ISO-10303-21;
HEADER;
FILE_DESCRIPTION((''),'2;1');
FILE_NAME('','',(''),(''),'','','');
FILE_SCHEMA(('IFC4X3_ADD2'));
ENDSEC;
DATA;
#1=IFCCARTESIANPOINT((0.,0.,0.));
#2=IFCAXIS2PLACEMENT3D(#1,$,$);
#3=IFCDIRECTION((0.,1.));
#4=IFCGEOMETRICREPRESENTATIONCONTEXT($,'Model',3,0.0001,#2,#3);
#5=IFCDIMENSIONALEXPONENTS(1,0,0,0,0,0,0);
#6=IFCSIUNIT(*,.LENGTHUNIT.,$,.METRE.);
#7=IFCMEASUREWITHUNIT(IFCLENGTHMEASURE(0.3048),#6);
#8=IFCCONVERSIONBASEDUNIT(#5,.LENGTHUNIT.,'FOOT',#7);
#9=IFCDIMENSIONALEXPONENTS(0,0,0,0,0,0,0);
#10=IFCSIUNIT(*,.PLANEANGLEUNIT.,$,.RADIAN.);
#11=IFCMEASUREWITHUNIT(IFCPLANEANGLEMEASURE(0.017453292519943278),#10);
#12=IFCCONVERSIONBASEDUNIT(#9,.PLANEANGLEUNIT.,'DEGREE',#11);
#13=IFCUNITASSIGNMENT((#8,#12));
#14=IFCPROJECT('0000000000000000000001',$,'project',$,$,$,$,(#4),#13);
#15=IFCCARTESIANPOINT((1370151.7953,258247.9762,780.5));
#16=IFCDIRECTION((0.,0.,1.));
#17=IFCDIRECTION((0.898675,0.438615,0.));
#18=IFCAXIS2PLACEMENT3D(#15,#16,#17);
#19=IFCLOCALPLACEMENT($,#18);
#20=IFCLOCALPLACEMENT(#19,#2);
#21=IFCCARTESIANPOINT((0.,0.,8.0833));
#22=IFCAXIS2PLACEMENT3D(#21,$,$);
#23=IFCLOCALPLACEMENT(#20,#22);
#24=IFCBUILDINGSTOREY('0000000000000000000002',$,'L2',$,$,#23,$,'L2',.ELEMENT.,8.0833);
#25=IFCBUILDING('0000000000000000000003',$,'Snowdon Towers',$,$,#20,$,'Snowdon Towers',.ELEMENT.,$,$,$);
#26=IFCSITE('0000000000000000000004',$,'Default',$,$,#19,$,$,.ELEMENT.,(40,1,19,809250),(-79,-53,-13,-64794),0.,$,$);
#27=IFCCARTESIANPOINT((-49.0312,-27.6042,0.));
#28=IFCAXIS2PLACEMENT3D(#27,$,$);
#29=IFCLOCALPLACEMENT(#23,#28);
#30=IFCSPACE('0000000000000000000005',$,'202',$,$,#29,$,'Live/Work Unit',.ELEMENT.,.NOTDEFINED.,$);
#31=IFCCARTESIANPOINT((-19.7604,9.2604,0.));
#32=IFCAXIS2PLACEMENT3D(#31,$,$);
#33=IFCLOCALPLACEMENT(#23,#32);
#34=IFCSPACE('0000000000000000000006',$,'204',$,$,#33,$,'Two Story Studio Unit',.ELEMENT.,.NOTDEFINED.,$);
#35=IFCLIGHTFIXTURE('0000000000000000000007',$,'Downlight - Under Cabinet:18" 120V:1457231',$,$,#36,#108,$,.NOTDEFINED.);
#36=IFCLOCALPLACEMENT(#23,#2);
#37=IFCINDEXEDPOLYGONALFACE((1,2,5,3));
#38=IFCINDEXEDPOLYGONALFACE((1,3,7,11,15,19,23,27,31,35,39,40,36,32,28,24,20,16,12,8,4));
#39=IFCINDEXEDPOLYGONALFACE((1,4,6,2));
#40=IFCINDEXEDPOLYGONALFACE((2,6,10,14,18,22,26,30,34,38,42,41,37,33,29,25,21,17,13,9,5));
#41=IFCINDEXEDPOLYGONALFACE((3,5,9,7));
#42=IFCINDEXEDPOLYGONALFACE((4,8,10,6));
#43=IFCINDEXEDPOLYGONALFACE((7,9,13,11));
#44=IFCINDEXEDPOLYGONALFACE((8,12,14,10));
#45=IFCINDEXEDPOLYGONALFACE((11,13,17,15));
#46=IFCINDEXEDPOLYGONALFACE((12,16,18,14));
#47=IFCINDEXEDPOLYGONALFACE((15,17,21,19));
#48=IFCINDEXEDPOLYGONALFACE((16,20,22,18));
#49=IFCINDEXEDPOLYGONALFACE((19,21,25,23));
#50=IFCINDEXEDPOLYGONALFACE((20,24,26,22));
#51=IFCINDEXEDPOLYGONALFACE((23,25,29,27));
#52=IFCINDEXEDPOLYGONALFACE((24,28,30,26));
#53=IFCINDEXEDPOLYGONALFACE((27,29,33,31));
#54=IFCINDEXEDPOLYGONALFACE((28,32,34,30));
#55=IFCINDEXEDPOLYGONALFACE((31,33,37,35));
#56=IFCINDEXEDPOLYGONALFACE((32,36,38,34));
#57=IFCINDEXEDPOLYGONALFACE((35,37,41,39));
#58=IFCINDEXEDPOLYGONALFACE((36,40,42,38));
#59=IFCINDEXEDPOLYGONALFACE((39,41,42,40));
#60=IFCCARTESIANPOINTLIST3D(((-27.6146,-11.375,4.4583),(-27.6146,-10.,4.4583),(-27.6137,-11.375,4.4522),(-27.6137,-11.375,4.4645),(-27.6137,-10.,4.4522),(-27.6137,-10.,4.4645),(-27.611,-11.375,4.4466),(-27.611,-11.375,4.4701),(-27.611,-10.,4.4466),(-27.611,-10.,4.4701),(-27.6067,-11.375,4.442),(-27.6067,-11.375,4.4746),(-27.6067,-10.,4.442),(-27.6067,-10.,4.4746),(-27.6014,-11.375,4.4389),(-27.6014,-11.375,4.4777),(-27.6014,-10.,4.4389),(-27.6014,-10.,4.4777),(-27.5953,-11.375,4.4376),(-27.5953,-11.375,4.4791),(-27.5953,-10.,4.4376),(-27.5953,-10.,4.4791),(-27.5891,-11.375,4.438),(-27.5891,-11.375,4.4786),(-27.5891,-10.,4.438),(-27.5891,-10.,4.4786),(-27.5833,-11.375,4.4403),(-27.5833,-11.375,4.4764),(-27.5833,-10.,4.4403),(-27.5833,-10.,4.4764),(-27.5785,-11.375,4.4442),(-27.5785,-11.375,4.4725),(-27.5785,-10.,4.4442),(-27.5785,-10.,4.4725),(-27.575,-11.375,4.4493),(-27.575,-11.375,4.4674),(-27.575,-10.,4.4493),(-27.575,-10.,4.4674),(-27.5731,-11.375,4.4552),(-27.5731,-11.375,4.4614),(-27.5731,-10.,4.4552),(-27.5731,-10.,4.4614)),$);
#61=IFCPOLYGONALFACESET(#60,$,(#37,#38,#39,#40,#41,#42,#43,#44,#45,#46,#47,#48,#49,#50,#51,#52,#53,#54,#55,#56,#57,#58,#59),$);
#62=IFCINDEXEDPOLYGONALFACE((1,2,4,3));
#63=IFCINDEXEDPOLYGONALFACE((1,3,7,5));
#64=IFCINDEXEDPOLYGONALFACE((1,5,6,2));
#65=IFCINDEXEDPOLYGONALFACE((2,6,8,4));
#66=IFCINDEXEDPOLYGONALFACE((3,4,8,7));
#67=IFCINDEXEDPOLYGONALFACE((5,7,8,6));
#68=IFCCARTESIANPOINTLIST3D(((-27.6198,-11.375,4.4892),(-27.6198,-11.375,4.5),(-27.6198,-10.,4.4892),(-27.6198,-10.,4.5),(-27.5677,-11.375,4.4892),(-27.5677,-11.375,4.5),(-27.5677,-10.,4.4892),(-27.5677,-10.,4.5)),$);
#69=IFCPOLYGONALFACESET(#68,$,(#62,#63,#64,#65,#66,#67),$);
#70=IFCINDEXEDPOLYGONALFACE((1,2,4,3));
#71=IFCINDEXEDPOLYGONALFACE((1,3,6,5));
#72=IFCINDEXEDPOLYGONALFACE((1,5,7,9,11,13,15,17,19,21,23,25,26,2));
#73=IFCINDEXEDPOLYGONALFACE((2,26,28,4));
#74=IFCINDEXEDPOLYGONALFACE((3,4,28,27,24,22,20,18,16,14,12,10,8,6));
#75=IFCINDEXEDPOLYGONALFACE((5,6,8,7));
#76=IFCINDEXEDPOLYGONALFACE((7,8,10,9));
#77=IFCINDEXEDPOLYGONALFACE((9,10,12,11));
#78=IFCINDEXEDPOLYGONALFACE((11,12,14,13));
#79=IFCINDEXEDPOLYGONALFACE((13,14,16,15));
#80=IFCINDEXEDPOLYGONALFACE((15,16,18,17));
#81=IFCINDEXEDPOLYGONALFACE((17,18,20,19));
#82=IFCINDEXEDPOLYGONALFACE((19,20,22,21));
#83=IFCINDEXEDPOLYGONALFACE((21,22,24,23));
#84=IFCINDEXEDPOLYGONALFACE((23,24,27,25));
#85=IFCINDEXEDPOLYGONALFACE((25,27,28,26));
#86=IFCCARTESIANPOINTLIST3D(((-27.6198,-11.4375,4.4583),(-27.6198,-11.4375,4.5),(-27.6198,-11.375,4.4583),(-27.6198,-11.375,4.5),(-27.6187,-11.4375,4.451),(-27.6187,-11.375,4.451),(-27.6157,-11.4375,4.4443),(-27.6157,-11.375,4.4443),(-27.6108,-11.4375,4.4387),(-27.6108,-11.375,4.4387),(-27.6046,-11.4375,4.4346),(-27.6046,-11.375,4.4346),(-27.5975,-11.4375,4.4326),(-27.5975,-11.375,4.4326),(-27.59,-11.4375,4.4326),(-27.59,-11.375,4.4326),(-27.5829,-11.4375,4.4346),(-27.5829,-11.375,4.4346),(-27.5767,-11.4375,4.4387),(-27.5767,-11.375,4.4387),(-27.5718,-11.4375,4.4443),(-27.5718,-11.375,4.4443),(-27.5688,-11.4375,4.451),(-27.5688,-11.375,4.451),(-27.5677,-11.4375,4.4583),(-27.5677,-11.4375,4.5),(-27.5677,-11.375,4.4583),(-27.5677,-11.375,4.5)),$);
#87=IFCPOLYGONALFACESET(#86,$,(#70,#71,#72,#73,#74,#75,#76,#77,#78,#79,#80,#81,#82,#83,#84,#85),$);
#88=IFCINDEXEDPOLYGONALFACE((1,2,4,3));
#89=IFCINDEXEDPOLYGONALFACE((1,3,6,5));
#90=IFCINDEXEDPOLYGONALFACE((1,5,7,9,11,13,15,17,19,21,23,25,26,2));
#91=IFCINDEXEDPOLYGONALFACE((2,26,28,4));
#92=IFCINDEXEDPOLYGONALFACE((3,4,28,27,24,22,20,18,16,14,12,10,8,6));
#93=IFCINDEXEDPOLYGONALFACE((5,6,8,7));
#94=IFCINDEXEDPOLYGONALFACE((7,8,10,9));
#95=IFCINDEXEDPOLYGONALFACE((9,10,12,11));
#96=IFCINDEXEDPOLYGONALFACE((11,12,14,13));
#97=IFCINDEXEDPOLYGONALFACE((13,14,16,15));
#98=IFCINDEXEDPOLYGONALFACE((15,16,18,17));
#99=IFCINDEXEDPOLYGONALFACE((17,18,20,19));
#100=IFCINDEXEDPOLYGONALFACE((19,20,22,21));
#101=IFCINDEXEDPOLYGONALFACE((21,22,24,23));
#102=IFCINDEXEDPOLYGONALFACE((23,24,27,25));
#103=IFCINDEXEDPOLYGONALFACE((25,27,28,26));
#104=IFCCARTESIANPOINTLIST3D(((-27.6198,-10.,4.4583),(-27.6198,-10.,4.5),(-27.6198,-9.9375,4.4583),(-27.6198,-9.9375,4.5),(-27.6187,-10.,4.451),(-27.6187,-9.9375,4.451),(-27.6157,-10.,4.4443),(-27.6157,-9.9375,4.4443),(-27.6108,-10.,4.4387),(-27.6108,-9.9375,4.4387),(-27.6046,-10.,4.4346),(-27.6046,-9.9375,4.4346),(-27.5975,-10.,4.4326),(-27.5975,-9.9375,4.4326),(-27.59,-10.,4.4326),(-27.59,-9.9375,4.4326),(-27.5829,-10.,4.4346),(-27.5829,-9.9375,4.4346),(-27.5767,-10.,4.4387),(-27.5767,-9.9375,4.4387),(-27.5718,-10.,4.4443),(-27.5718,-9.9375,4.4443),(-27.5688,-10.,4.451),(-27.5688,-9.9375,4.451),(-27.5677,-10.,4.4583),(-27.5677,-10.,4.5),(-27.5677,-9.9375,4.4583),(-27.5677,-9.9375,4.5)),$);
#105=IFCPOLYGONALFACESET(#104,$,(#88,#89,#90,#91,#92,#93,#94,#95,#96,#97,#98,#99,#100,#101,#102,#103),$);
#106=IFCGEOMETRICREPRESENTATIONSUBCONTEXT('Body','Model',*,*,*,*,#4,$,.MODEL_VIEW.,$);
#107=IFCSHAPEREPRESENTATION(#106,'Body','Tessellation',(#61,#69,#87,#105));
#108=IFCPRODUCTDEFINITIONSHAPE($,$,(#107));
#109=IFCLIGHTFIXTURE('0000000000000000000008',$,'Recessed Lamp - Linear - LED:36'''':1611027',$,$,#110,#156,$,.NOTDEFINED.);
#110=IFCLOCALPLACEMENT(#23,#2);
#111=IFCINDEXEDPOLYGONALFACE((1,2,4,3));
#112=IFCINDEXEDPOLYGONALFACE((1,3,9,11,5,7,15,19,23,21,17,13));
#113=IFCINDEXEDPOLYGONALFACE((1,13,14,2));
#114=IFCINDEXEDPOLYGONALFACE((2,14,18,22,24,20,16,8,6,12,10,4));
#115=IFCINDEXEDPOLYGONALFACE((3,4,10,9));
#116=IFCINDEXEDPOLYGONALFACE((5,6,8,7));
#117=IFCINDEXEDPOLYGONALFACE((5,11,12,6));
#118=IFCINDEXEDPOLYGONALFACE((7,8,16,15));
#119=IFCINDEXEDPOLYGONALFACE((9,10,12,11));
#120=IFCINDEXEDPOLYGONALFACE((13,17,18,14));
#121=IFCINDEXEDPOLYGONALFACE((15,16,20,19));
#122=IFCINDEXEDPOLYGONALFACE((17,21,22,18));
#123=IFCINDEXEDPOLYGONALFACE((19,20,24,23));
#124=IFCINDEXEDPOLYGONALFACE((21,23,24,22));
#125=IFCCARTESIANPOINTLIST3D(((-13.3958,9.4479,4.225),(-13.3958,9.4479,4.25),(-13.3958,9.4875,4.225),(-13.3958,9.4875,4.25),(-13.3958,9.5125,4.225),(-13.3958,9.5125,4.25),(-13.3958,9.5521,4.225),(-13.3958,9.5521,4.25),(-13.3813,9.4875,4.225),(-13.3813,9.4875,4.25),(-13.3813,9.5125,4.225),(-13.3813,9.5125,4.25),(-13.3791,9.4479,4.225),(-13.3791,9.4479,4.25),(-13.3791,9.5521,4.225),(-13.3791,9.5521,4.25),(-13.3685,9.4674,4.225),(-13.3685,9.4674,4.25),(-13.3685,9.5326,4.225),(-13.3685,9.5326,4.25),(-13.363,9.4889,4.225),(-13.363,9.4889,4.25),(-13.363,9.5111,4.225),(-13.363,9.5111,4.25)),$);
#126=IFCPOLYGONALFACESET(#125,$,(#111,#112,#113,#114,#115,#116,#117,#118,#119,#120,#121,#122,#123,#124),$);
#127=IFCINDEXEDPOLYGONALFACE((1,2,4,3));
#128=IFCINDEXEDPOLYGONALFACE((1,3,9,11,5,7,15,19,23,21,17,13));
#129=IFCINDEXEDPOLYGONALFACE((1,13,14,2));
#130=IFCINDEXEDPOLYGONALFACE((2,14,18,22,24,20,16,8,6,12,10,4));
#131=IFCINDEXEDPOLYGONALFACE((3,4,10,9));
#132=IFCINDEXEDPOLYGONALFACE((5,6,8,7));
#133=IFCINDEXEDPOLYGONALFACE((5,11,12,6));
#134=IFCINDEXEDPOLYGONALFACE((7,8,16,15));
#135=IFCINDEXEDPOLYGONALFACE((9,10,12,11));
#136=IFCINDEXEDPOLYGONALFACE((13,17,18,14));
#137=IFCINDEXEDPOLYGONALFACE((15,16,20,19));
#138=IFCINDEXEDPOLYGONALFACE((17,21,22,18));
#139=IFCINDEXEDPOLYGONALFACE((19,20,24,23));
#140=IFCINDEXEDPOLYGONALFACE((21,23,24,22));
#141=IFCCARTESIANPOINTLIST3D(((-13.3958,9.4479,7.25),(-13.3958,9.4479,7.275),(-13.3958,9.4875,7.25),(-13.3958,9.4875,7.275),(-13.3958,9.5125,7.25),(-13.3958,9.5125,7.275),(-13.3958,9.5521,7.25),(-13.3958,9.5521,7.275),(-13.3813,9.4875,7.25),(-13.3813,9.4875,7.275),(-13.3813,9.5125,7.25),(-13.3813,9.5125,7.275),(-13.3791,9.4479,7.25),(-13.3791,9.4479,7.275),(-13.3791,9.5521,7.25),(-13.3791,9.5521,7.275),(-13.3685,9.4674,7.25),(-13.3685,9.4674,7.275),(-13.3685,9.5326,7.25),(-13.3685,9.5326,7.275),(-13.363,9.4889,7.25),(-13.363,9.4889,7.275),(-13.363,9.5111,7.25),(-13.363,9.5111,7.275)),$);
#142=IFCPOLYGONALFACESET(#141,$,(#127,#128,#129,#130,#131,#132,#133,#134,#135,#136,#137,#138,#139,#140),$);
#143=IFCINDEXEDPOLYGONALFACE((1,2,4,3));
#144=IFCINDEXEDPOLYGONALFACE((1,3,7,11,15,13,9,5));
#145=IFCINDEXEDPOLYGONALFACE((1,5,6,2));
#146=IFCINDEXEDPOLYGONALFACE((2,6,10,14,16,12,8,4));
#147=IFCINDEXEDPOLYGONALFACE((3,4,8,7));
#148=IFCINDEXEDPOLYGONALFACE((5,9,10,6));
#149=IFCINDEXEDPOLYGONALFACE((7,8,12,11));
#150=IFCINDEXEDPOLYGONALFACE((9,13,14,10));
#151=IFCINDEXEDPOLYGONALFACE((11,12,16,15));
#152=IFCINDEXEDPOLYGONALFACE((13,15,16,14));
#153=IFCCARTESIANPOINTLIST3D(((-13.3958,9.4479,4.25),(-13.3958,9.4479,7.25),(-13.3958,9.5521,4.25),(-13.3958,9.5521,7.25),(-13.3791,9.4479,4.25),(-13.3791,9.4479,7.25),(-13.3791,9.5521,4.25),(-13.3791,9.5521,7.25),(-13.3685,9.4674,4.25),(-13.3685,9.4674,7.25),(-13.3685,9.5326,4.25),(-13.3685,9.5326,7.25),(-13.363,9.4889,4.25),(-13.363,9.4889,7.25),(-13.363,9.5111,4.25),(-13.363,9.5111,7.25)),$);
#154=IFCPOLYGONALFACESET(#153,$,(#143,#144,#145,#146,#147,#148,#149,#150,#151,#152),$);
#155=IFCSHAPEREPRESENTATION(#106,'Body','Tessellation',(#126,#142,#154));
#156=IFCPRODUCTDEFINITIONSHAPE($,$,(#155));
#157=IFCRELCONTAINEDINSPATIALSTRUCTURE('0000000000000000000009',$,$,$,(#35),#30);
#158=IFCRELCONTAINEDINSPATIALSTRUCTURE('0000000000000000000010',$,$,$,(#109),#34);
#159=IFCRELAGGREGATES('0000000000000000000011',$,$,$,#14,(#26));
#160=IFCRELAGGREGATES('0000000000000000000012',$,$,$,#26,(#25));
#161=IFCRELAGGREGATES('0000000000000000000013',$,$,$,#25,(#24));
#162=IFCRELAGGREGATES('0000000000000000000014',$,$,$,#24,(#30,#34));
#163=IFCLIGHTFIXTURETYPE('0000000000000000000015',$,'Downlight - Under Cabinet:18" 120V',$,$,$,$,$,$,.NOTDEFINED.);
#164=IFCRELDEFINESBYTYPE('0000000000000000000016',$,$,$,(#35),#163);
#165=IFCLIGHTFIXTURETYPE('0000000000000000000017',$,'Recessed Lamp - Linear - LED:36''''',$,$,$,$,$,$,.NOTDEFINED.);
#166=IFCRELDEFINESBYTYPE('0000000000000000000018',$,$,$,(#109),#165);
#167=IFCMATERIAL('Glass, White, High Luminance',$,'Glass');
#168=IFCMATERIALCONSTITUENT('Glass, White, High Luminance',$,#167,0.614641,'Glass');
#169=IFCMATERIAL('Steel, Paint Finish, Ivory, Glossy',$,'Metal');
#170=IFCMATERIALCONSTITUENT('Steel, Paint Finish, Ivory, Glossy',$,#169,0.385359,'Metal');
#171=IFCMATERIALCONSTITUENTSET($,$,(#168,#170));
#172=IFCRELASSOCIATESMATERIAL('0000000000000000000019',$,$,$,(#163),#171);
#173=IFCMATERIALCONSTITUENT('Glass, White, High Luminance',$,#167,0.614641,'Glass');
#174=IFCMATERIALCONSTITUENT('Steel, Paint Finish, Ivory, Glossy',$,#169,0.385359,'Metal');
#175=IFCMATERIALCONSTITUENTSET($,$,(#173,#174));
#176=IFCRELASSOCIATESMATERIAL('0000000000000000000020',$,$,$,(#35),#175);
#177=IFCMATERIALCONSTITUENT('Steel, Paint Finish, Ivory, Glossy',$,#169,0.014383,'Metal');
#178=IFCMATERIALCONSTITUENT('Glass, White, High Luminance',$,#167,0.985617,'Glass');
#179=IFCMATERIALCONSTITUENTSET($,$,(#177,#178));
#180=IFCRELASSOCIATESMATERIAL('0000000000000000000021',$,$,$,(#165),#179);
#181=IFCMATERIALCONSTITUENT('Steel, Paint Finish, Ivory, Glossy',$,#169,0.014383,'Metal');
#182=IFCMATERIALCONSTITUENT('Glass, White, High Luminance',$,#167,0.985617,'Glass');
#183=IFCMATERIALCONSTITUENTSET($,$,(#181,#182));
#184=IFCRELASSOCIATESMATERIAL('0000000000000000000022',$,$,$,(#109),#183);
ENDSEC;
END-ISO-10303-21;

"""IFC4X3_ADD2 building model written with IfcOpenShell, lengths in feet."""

from ifc_helpers import new_model, entity, si_unit, converted_unit, direction, frame, frame_2d, origin, origin_2d_with_axis, place, context, subcontext, project, spatial, polyline, circle_curve, parameter, trimmed, segment, composite_curve, rectangle, circle, outline, extrude, source, transform, mapped, material, constituent, constituent_set, type_object, type_shapes, element, save


model = new_model("IFC4X3_ADD2")

# Units and contexts
model_context = context("Model", 3, precision=0.0001, world=origin(), true_north=direction((0.0, 1.0)))
body_context = subcontext(model_context, "Body", "Model", "MODEL_VIEW")
ifc_project = project(units=[converted_unit("LENGTHUNIT", "FOOT", entity("IfcLengthMeasure", 0.3048), si_unit("LENGTHUNIT", "METRE"), dimensions=[1, 0, 0, 0, 0, 0, 0]), converted_unit("PLANEANGLEUNIT", "DEGREE", entity("IfcPlaneAngleMeasure", 0.017453292519943278), si_unit("PLANEANGLEUNIT", "RADIAN"), dimensions=[0, 0, 0, 0, 0, 0, 0])], contexts=[model_context])

# Site, building, storey, space
site_placement = place(None, frame((1370151.7953, 258247.9762, 780.5), z_axis=(0.0, 0.0, 1.0), x_axis=(0.898675, 0.438615, 0.0)))
site = spatial("IfcSite", under=ifc_project, at=site_placement, Name="Default", CompositionType="ELEMENT", RefLatitude=(40, 1, 19, 809250), RefLongitude=(-79, -53, -13, -64794), RefElevation=0.0)
building_placement = place(site_placement, origin())
building = spatial("IfcBuilding", under=site, at=building_placement, Name="Snowdon Towers", LongName="Snowdon Towers", CompositionType="ELEMENT")
storey_placement = place(building_placement, frame((0.0, 0.0, 8.0833)))
storey = spatial("IfcBuildingStorey", under=building, at=storey_placement, Name="L2", LongName="L2", CompositionType="ELEMENT", Elevation=8.0833)
space_1_placement = place(storey_placement, frame((-49.0312, -27.6042, 0.0)))
space_1 = spatial("IfcSpace", under=storey, at=space_1_placement, Name="202", LongName="Live/Work Unit", CompositionType="ELEMENT", PredefinedType="NOTDEFINED")

# Shared definitions
space_2_placement = place(storey_placement, frame((-19.7604, 9.2604, 0.0)))
space_2 = spatial("IfcSpace", under=storey, at=space_2_placement, Name="204", LongName="Two Story Studio Unit", CompositionType="ELEMENT", PredefinedType="NOTDEFINED")

# Light fixtures
ifc_material_1 = material(Name="Glass, White, High Luminance", Category="Glass")
ifc_constituent_1 = constituent(ifc_material_1, Name="Glass, White, High Luminance", Category="Glass", fraction=0.614641)
ifc_material_2 = material(Name="Steel, Paint Finish, Ivory, Glossy", Category="Metal")
ifc_constituent_2 = constituent(ifc_material_2, Name="Steel, Paint Finish, Ivory, Glossy", Category="Metal", fraction=0.385359)
ifc_constituent_set_1 = constituent_set(constituents=[ifc_constituent_1, ifc_constituent_2])
ifc_constituent_3 = constituent(ifc_material_1, Name="Glass, White, High Luminance", Category="Glass", fraction=0.614641)
ifc_constituent_4 = constituent(ifc_material_2, Name="Steel, Paint Finish, Ivory, Glossy", Category="Metal", fraction=0.385359)
ifc_constituent_set_2 = constituent_set(constituents=[ifc_constituent_3, ifc_constituent_4])
light_fixture_type_1 = type_object("IfcLightFixtureType", Name="Downlight - Under Cabinet:18\" 120V", PredefinedType="NOTDEFINED", material=ifc_constituent_set_2)
shared_shape_1 = source(origin(), body_context, "Body", "SweptSolid", [
    extrude(circle(Radius=0.0208, at=origin_2d_with_axis()), frame((-0.6875, 0.0, 4.4583), z_axis=(1.0, 0.0, 0.0), x_axis=(0.0, 1.0, 0.0)), (0.0, 0.0, 1.0), 1.375),
    extrude(rectangle(XDim=1.375, YDim=0.0521, at=origin_2d_with_axis()), frame((0.0, 0.0, 4.4892), z_axis=(0.0, 0.0, 1.0), x_axis=(-1.0, 0.0, 0.0)), (0.0, 0.0, 1.0), 0.0108),
    extrude(outline(composite_curve([segment(polyline([(-0.026, -0.0208), (0.026, -0.0208)]), True, "CONTINUOUS"), segment(polyline([(0.026, -0.0208), (0.026, 0.0208)]), True, "CONTINUOUS"), segment(trimmed(circle_curve(frame_2d((0.0, 0.0208), x_axis=(0.0, -1.0)), 0.026), [parameter(90.0)], [parameter(270.0)], True, "PARAMETER"), True, "CONTINUOUS"), segment(polyline([(-0.026, 0.0208), (-0.026, -0.0208)]), True, "CONTINUOUS")], self_intersect=False)), frame((-0.75, 0.0, 4.4792), z_axis=(1.0, 0.0, 0.0), x_axis=(0.0, -1.0, 0.0)), (0.0, 0.0, 1.0), 0.0625),
    extrude(outline(composite_curve([segment(polyline([(-0.0208, -0.026), (0.0208, -0.026)]), True, "CONTINUOUS"), segment(trimmed(circle_curve(frame_2d((0.0208, 0.0), x_axis=(0.0, 1.0)), 0.026), [parameter(180.0)], [parameter(360.0)], True, "PARAMETER"), True, "CONTINUOUS"), segment(polyline([(0.0208, 0.026), (-0.0208, 0.026)]), True, "CONTINUOUS"), segment(polyline([(-0.0208, 0.026), (-0.0208, -0.026)]), True, "CONTINUOUS")], self_intersect=False)), frame((0.6875, 0.0, 4.4792), z_axis=(1.0, 0.0, 0.0), x_axis=(0.0, 0.0, -1.0)), (0.0, 0.0, 1.0), 0.0625),
])
type_shapes(light_fixture_type_1, [shared_shape_1])
light_fixture_1_placement = place(space_1_placement, frame((21.4375, 16.9167, 0.0), z_axis=(0.0, 0.0, 1.0), x_axis=(0.0, 1.0, 0.0)))
element("IfcLightFixture", 1, at=light_fixture_1_placement, inside=space_1, type_object=light_fixture_type_1, material=ifc_constituent_set_1, Name="Downlight - Under Cabinet:18\" 120V:1457231", PredefinedType="NOTDEFINED", context=body_context, shape_type="MappedRepresentation", body=[
    mapped(shared_shape_1, transform((0.0, 0.0, 0.0), scale=1.0)),
])
ifc_constituent_5 = constituent(ifc_material_2, Name="Steel, Paint Finish, Ivory, Glossy", Category="Metal", fraction=0.014383)
ifc_constituent_6 = constituent(ifc_material_1, Name="Glass, White, High Luminance", Category="Glass", fraction=0.985617)
ifc_constituent_set_3 = constituent_set(constituents=[ifc_constituent_5, ifc_constituent_6])
ifc_constituent_7 = constituent(ifc_material_2, Name="Steel, Paint Finish, Ivory, Glossy", Category="Metal", fraction=0.014383)
ifc_constituent_8 = constituent(ifc_material_1, Name="Glass, White, High Luminance", Category="Glass", fraction=0.985617)
ifc_constituent_set_4 = constituent_set(constituents=[ifc_constituent_7, ifc_constituent_8])
light_fixture_type_2 = type_object("IfcLightFixtureType", Name="Recessed Lamp - Linear - LED:36''", PredefinedType="NOTDEFINED", material=ifc_constituent_set_4)
shared_shape_2 = source(origin(), body_context, "Body", "SweptSolid", [
    extrude(outline(composite_curve([segment(trimmed(circle_curve(frame_2d((0.0, -0.0633), x_axis=(1.0, 0.0)), 0.089), [parameter(54.196986)], [parameter(125.803014)], True, "PARAMETER"), True, "CONTINUOUS"), segment(polyline([(-0.0521, 0.0089), (-0.0521, -0.0078)]), True, "CONTINUOUS"), segment(polyline([(-0.0521, -0.0078), (-0.0125, -0.0078)]), True, "CONTINUOUS"), segment(polyline([(-0.0125, -0.0078), (-0.0125, 0.0068)]), True, "CONTINUOUS"), segment(polyline([(-0.0125, 0.0068), (0.0125, 0.0068)]), True, "CONTINUOUS"), segment(polyline([(0.0125, 0.0068), (0.0125, -0.0078)]), True, "CONTINUOUS"), segment(polyline([(0.0125, -0.0078), (0.0521, -0.0078)]), True, "CONTINUOUS"), segment(polyline([(0.0521, -0.0078), (0.0521, 0.0089)]), True, "CONTINUOUS")], self_intersect=False)), frame((-1.525, 0.0, 0.0078), z_axis=(1.0, 0.0, 0.0), x_axis=(0.0, 1.0, 0.0)), (0.0, 0.0, 1.0), 0.025),
    extrude(outline(composite_curve([segment(trimmed(circle_curve(frame_2d((0.0, -0.0633), x_axis=(1.0, 0.0)), 0.089), [parameter(54.196986)], [parameter(125.803014)], True, "PARAMETER"), True, "CONTINUOUS"), segment(polyline([(-0.0521, 0.0089), (-0.0521, -0.0078)]), True, "CONTINUOUS"), segment(polyline([(-0.0521, -0.0078), (-0.0125, -0.0078)]), True, "CONTINUOUS"), segment(polyline([(-0.0125, -0.0078), (-0.0125, 0.0068)]), True, "CONTINUOUS"), segment(polyline([(-0.0125, 0.0068), (0.0125, 0.0068)]), True, "CONTINUOUS"), segment(polyline([(0.0125, 0.0068), (0.0125, -0.0078)]), True, "CONTINUOUS"), segment(polyline([(0.0125, -0.0078), (0.0521, -0.0078)]), True, "CONTINUOUS"), segment(polyline([(0.0521, -0.0078), (0.0521, 0.0089)]), True, "CONTINUOUS")], self_intersect=False)), frame((1.5, 0.0, 0.0078), z_axis=(1.0, 0.0, 0.0), x_axis=(0.0, 1.0, 0.0)), (0.0, 0.0, 1.0), 0.025),
    extrude(outline(composite_curve([segment(trimmed(circle_curve(frame_2d((0.0, -0.0639), x_axis=(1.0, 0.0)), 0.089), [parameter(54.196986)], [parameter(125.803014)], True, "PARAMETER"), True, "CONTINUOUS"), segment(polyline([(-0.0521, 0.0083), (-0.0521, -0.0083)]), True, "CONTINUOUS"), segment(polyline([(-0.0521, -0.0083), (0.0521, -0.0083)]), True, "CONTINUOUS"), segment(polyline([(0.0521, -0.0083), (0.0521, 0.0083)]), True, "CONTINUOUS")], self_intersect=False)), frame((-1.5, 0.0, 0.0083), z_axis=(1.0, 0.0, 0.0), x_axis=(0.0, 1.0, 0.0)), (0.0, 0.0, 1.0), 3.0),
])
type_shapes(light_fixture_type_2, [shared_shape_2])
light_fixture_2_placement = place(space_2_placement, frame((6.3646, 0.2396, 5.75), z_axis=(1.0, 0.0, 0.0), x_axis=(0.0, 0.0, 1.0)))
element("IfcLightFixture", 2, at=light_fixture_2_placement, inside=space_2, type_object=light_fixture_type_2, material=ifc_constituent_set_3, Name="Recessed Lamp - Linear - LED:36'':1611027", PredefinedType="NOTDEFINED", context=body_context, shape_type="MappedRepresentation", body=[
    mapped(shared_shape_2, transform((0.0, 0.0, 0.0), scale=1.0)),
])

save(model, "model.ifc")
